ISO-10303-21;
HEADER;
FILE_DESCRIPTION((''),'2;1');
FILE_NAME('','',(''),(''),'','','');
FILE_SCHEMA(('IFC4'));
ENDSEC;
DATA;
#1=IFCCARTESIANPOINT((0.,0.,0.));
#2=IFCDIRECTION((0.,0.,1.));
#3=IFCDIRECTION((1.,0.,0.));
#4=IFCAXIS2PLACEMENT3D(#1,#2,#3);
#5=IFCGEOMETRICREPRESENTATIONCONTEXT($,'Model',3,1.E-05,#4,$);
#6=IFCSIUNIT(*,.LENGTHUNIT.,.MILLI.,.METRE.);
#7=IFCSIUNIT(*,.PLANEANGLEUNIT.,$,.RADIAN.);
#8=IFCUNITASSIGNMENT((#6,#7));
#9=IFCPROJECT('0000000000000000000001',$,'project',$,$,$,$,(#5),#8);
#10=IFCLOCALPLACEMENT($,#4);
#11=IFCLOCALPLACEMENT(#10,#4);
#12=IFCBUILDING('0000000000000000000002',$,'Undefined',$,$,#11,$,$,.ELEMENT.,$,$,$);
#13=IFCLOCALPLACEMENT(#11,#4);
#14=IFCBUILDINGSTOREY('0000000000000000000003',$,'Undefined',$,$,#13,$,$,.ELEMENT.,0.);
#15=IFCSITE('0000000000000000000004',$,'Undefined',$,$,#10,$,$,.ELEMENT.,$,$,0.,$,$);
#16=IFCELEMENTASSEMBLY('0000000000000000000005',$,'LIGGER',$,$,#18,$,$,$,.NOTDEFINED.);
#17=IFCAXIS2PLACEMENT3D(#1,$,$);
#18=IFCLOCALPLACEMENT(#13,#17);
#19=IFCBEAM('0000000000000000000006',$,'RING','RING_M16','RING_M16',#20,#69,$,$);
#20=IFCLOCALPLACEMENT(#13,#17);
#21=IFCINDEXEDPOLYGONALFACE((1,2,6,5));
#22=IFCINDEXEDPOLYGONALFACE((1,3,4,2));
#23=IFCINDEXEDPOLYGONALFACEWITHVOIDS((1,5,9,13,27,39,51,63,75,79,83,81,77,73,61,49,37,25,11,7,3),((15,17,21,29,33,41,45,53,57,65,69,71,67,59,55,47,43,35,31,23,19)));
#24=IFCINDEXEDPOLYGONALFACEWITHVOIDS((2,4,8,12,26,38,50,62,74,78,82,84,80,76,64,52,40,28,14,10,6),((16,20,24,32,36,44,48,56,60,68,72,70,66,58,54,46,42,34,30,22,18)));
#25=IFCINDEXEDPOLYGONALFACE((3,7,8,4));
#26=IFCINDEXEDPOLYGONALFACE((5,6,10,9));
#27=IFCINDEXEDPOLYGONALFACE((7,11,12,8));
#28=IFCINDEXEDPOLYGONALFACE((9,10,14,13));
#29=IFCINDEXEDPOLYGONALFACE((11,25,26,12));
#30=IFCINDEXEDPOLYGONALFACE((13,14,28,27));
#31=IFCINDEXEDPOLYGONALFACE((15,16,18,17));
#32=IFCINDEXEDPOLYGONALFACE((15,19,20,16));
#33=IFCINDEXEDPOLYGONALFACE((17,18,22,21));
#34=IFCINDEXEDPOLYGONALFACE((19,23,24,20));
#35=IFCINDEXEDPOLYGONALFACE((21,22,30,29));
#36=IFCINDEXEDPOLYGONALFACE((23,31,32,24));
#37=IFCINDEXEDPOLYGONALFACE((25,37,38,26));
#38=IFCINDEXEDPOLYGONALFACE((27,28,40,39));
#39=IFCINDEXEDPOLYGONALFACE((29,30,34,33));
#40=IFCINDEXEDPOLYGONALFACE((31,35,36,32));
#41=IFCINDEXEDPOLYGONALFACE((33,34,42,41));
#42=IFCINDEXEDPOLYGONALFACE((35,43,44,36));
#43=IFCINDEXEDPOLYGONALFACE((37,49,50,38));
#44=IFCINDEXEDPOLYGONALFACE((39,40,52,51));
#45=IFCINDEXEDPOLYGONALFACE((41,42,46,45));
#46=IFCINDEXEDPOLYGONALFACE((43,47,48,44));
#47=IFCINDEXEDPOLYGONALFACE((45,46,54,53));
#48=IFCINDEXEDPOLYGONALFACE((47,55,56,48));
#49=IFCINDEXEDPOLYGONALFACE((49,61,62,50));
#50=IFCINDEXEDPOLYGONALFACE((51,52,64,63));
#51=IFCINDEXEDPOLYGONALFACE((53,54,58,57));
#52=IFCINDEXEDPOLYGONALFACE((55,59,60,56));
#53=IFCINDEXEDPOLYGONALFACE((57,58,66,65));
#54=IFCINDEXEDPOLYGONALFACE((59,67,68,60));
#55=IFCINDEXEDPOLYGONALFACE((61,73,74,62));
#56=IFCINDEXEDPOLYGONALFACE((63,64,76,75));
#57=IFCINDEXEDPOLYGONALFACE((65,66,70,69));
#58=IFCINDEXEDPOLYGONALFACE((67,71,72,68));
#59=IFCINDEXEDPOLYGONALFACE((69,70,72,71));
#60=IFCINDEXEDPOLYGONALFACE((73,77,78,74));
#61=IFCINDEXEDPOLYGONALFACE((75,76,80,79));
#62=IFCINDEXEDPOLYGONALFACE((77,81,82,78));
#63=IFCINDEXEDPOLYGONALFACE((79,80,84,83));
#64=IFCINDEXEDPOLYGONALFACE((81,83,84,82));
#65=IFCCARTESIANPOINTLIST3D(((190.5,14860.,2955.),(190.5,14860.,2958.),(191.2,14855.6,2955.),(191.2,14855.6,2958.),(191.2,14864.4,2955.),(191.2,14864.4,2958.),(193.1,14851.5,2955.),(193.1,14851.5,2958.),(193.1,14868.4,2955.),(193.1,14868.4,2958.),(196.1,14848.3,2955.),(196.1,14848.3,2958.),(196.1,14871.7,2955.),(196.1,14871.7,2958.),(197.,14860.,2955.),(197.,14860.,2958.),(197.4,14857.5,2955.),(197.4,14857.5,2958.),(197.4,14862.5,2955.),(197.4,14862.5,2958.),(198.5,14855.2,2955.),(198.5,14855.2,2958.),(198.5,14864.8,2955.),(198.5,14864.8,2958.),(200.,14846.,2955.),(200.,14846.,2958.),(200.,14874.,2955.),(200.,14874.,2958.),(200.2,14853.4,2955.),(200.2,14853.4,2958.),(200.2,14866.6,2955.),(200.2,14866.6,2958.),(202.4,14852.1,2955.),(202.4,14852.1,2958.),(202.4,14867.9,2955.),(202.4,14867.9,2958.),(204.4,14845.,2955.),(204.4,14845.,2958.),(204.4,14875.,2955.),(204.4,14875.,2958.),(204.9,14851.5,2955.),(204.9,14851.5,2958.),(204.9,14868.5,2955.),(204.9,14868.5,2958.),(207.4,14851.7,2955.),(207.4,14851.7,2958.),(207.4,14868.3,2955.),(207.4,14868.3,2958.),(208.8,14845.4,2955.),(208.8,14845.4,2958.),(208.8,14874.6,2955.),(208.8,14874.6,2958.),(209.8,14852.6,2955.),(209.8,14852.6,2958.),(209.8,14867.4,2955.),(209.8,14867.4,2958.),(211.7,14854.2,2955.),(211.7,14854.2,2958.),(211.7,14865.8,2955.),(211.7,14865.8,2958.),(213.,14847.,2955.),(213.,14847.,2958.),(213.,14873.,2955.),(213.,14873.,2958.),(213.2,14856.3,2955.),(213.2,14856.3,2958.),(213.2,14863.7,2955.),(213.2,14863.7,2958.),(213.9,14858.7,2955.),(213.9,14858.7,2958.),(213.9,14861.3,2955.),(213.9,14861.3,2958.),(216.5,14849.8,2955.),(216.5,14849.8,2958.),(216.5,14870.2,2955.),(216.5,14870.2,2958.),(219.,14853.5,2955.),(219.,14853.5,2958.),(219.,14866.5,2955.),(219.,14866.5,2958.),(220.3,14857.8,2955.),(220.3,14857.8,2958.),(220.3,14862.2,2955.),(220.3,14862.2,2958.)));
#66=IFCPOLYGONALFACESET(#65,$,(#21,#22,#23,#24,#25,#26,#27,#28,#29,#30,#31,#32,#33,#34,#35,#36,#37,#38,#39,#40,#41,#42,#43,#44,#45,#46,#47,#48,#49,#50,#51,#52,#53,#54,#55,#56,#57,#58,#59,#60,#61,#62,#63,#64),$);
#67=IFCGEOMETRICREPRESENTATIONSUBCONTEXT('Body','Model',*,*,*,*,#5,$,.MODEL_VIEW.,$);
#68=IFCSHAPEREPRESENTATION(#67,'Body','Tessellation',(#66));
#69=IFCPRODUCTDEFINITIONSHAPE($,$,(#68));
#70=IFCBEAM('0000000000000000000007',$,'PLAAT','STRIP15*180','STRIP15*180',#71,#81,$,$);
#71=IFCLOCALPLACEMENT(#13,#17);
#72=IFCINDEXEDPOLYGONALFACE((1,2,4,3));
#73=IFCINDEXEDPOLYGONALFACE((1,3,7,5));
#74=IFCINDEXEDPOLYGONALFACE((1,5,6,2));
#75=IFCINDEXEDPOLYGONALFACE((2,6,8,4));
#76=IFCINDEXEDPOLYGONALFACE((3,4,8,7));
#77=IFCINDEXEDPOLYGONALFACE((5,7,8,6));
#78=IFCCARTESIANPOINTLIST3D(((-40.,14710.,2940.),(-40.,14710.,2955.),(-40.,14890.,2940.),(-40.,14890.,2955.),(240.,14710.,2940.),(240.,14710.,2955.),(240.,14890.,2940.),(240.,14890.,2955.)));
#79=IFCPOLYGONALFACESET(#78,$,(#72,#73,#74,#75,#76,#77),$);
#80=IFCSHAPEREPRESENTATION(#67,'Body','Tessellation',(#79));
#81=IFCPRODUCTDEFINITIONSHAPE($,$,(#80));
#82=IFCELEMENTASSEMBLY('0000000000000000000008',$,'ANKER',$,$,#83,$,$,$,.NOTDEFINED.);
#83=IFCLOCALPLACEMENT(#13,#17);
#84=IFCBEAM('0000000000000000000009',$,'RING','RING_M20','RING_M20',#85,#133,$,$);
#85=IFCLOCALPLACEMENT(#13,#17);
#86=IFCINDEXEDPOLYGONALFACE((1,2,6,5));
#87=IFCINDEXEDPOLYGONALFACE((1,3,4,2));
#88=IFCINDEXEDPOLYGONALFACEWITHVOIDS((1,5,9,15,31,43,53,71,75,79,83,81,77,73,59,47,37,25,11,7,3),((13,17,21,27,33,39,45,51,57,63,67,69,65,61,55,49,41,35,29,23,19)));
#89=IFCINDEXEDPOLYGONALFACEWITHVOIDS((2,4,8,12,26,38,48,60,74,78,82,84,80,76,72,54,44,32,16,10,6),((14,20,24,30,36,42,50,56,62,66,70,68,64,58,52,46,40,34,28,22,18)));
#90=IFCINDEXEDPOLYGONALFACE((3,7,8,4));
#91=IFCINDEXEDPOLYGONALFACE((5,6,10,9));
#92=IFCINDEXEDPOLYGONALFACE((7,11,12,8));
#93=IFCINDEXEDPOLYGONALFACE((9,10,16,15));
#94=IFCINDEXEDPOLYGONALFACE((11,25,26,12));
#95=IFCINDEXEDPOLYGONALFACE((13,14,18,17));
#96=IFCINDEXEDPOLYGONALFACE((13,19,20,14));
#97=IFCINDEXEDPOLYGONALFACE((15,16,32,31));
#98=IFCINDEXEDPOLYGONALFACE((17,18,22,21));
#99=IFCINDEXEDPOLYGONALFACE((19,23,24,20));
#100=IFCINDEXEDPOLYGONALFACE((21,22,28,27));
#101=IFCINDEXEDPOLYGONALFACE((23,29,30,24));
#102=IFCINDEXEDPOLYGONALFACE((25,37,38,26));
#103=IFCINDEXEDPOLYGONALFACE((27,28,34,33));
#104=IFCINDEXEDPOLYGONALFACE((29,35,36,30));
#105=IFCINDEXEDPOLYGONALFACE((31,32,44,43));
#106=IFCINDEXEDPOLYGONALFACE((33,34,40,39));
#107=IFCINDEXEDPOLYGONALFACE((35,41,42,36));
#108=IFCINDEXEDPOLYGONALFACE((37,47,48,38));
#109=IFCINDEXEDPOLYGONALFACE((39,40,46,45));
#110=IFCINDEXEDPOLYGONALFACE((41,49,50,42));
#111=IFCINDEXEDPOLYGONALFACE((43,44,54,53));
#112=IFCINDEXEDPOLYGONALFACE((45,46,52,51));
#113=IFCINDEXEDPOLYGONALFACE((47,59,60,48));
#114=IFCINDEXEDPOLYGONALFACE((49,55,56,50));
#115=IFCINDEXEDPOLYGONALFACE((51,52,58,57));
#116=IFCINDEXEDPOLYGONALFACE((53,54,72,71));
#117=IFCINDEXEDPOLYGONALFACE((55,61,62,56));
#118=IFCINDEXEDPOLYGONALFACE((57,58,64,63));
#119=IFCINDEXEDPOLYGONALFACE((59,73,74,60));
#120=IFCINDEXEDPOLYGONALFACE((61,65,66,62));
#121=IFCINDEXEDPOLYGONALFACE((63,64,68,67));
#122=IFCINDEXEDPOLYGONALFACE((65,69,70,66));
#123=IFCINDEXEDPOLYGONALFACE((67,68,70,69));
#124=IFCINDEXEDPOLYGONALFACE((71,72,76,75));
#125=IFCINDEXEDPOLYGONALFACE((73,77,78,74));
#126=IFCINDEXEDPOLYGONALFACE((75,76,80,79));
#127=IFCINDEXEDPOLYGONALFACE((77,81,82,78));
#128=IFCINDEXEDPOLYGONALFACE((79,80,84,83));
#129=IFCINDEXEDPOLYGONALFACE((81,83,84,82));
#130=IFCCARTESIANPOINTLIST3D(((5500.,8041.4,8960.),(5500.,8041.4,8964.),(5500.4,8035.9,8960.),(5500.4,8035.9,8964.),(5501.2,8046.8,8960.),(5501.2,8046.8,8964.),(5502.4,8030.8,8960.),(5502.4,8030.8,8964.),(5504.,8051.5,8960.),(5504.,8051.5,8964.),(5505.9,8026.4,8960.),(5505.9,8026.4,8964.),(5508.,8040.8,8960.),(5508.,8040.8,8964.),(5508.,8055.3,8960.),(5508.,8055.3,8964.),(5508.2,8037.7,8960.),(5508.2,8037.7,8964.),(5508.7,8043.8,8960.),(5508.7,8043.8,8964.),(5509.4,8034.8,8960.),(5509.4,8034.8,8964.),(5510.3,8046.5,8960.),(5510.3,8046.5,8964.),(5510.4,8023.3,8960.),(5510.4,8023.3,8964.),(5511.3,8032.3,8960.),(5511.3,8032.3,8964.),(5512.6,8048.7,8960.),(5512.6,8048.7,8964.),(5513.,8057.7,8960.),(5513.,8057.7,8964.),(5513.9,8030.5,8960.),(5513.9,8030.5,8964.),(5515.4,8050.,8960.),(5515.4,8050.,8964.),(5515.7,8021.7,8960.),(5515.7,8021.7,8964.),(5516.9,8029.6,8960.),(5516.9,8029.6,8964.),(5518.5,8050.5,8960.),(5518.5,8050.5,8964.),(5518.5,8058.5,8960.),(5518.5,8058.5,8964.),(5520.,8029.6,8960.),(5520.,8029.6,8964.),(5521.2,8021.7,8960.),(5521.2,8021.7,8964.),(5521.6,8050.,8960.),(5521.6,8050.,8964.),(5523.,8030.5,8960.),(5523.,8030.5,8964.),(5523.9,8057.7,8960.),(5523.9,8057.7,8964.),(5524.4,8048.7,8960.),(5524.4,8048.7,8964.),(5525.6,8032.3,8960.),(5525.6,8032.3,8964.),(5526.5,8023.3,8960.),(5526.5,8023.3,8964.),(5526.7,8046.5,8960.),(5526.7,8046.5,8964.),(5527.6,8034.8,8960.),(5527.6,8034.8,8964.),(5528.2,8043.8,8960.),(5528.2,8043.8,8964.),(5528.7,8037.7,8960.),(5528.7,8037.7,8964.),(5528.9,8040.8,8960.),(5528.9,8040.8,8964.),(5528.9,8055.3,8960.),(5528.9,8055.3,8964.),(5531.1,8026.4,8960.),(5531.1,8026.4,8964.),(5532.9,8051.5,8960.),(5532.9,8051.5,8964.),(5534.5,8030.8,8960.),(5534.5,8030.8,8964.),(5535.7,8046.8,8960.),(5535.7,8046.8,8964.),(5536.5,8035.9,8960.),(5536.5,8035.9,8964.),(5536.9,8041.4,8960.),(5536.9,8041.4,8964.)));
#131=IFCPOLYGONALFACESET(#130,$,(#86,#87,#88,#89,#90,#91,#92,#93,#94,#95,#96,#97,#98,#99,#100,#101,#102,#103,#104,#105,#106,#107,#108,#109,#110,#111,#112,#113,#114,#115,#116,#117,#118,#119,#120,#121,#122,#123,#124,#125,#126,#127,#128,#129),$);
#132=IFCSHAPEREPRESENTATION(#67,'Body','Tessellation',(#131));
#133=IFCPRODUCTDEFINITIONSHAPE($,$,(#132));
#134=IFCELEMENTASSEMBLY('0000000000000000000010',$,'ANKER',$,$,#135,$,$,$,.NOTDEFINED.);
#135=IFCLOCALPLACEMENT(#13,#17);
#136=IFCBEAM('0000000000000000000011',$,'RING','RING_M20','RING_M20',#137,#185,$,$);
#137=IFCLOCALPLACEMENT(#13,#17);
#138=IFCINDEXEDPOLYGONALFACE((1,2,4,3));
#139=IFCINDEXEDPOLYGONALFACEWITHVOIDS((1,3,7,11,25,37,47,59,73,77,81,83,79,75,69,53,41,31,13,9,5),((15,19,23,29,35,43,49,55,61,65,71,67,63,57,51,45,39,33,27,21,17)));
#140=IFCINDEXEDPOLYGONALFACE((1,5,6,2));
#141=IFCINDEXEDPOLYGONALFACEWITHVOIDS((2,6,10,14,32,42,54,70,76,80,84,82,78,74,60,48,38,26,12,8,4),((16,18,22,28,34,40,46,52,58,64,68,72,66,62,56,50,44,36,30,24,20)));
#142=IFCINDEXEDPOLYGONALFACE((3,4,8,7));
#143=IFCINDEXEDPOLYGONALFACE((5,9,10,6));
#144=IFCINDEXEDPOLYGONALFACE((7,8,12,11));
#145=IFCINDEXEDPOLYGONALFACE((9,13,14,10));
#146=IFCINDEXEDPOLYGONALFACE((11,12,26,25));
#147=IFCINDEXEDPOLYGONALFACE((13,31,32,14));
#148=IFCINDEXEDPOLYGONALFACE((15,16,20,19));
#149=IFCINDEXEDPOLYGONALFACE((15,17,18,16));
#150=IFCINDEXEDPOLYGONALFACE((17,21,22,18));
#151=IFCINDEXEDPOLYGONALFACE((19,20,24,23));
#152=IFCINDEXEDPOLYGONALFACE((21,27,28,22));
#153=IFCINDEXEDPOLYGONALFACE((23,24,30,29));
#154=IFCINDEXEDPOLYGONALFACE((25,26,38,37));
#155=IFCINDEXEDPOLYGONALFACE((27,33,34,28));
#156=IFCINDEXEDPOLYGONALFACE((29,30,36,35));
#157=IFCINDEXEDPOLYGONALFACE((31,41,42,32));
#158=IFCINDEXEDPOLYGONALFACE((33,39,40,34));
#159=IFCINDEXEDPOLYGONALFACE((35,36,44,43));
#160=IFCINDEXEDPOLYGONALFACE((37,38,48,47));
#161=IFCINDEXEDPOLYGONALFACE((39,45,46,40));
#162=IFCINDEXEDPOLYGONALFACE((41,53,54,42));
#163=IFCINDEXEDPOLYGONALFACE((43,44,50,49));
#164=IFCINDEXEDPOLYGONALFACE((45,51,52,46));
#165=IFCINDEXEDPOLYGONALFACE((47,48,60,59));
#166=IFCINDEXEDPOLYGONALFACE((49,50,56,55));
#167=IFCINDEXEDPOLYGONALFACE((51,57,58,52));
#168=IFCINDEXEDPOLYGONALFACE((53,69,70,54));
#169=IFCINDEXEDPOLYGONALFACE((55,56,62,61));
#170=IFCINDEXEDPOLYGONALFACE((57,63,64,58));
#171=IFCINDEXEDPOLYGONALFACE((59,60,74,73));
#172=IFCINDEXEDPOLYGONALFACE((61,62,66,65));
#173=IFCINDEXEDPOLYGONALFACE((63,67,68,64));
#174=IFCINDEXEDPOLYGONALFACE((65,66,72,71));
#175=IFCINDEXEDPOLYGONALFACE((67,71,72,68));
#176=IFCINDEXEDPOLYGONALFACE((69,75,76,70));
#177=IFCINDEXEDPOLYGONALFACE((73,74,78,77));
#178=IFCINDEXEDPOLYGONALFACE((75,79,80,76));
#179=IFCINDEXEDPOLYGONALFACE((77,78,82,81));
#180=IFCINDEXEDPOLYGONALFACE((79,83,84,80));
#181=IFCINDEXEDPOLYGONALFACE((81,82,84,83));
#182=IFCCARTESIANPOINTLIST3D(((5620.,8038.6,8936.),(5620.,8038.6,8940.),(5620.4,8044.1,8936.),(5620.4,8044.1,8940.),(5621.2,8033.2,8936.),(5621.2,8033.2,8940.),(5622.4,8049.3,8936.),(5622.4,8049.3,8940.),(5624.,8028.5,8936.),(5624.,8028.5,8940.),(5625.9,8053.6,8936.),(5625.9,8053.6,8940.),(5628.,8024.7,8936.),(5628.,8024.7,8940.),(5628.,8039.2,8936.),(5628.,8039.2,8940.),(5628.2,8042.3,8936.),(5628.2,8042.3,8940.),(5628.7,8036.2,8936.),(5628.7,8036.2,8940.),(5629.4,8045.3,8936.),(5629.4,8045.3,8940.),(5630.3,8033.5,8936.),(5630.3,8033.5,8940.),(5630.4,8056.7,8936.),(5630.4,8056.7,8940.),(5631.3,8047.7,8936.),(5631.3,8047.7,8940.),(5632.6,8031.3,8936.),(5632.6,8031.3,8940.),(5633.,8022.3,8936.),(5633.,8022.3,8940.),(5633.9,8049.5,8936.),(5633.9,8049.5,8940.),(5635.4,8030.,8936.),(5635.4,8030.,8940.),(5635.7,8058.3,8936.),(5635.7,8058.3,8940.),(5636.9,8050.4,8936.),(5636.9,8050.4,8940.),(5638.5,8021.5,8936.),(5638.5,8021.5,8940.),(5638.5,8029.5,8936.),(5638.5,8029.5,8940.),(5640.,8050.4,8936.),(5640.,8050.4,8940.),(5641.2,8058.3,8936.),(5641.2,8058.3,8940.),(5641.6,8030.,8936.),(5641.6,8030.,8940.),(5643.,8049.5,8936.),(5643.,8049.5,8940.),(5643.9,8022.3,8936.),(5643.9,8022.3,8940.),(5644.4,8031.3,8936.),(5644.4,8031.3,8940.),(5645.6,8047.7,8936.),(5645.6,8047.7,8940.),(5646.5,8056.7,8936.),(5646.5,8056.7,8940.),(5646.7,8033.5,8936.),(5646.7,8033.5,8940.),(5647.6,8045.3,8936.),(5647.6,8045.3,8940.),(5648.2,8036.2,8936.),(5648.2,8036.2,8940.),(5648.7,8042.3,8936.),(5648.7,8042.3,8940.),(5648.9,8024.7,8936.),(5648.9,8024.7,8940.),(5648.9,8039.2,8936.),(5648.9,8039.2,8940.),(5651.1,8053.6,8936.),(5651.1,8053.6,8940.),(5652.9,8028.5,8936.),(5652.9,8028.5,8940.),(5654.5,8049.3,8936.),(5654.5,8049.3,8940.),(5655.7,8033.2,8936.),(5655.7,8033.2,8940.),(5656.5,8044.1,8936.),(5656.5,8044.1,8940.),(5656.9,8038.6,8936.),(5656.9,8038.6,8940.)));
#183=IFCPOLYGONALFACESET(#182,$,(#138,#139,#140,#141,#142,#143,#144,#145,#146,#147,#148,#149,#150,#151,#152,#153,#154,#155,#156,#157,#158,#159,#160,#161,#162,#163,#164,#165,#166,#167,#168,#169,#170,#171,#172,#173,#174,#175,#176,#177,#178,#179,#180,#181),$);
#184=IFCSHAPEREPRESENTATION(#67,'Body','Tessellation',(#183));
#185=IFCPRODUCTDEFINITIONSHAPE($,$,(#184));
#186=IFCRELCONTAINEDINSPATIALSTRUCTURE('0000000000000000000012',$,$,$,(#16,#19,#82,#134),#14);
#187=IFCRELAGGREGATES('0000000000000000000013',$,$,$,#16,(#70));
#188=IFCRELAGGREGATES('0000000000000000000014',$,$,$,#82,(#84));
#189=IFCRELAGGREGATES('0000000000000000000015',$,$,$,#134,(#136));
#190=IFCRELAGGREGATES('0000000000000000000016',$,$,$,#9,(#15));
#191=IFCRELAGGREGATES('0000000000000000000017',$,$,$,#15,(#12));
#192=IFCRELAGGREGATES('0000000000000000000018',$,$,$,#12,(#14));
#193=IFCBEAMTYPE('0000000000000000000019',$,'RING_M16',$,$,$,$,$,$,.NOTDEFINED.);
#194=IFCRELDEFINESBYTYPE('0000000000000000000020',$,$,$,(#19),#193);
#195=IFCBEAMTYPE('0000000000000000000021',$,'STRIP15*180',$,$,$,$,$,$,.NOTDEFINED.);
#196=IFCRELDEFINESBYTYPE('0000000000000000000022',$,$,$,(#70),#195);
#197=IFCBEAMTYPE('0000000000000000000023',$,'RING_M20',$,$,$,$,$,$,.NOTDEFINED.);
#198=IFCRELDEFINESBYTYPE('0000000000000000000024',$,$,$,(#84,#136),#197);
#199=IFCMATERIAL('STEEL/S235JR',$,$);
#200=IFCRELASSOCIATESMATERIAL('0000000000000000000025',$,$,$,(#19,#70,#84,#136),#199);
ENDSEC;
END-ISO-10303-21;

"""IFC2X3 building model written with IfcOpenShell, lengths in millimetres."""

from ifc_helpers import new_model, si_unit, frame, origin_with_axes, origin_2d_with_axis, place, context, subcontext, project, spatial, rectangle, hollow_circle, extrude, material, type_object, element, aggregate, save


model = new_model("IFC2X3")

# Units and contexts
model_context = context("Model", 3, precision=1e-05, world=origin_with_axes())
body_context = subcontext(model_context, "Body", "Model", "MODEL_VIEW")
ifc_project = project(units=[si_unit("LENGTHUNIT", "METRE", prefix="MILLI"), si_unit("PLANEANGLEUNIT", "RADIAN")], contexts=[model_context])

# Site, building, storey
site_placement = place(None, origin_with_axes())
site = spatial("IfcSite", under=ifc_project, at=site_placement, Name="Undefined", CompositionType="ELEMENT", RefElevation=0.0)
building_placement = place(site_placement, origin_with_axes())
building = spatial("IfcBuilding", under=site, at=building_placement, Name="Undefined", CompositionType="ELEMENT")
storey_placement = place(building_placement, origin_with_axes())
storey = spatial("IfcBuildingStorey", under=building, at=storey_placement, Name="Undefined", CompositionType="ELEMENT", Elevation=0.0)

# Shared definitions
ifc_material = material(Name="STEEL/S235JR")

# Element assembly
assembly_1_placement = place(storey_placement, frame((810.1, 14800.0, 5743.0), z_axis=(0.0, 0.0, 1.0), x_axis=(1.0, 0.0, 0.0)))
assembly_1 = element("IfcElementAssembly", 1, at=assembly_1_placement, inside=storey, Name="LIGGER", PredefinedType="NOTDEFINED")

# Shared definitions
beam_type_1 = type_object("IfcBeamType", Name="RING_M16", PredefinedType="NOTDEFINED")

# Beams
beam_1_placement = place(storey_placement, frame((205.5, 14860.0, 2958.0), z_axis=(0.0, -1.0, 0.0), x_axis=(0.0, 0.0, -1.0)))
element("IfcBeam", 2, at=beam_1_placement, inside=storey, type_object=beam_type_1, material=ifc_material, Name="RING", Description="RING_M16", ObjectType="RING_M16", context=body_context, shape_type="SweptSolid", body=[
    extrude(hollow_circle(Radius=15.0, WallThickness=6.5, at=origin_2d_with_axis()), frame((3.0, 0.0, 0.0), z_axis=(-1.0, 0.0, 0.0), x_axis=(0.0, -1.0, 0.0)), (0.0, 0.0, 1.0), 3.0),
])
beam_type_2 = type_object("IfcBeamType", Name="STRIP15*180", PredefinedType="NOTDEFINED")
beam_2_placement = place(storey_placement, frame((100.0, 14710.0, 2947.5), z_axis=(-1.0, 0.0, 0.0), x_axis=(0.0, 1.0, 0.0)))
beam_2 = element("IfcBeam", 3, at=beam_2_placement, type_object=beam_type_2, material=ifc_material, Name="PLAAT", Description="STRIP15*180", ObjectType="STRIP15*180", context=body_context, shape_type="SweptSolid", body=[
    extrude(rectangle(XDim=15.0, YDim=280.0, at=origin_2d_with_axis()), frame((180.0, 0.0, 0.0), z_axis=(-1.0, 0.0, 0.0), x_axis=(0.0, -1.0, 0.0)), (0.0, 0.0, 1.0), 180.0),
])
aggregate(assembly_1, [beam_2])

# Element assembly, beam
assembly_2_placement = place(storey_placement, frame((5518.5, 8040.0, 9010.0), z_axis=(0.0, 1.0, 0.0), x_axis=(0.0, 0.0, -1.0)))
assembly_2 = element("IfcElementAssembly", 4, at=assembly_2_placement, inside=storey, Name="ANKER", PredefinedType="NOTDEFINED")
beam_type_3 = type_object("IfcBeamType", Name="RING_M20", PredefinedType="NOTDEFINED")
beam_3_placement = place(storey_placement, frame((5518.5, 8040.0, 8964.0), z_axis=(-1.0, 0.0, 0.0), x_axis=(0.0, 0.0, -1.0)))
beam_3 = element("IfcBeam", 5, at=beam_3_placement, type_object=beam_type_3, material=ifc_material, Name="RING", Description="RING_M20", ObjectType="RING_M20", context=body_context, shape_type="SweptSolid", body=[
    extrude(hollow_circle(Radius=18.5, WallThickness=8.0, at=origin_2d_with_axis()), frame((4.0, 0.0, 0.0), z_axis=(-1.0, 0.0, 0.0), x_axis=(0.0, -1.0, 0.0)), (0.0, 0.0, 1.0), 4.0),
])
aggregate(assembly_2, [beam_3])

# Element assembly, beam
assembly_3_placement = place(storey_placement, frame((5638.5, 8040.0, 9010.0), z_axis=(0.0, 1.0, 0.0), x_axis=(0.0, 0.0, -1.0)))
assembly_3 = element("IfcElementAssembly", 6, at=assembly_3_placement, inside=storey, Name="ANKER", PredefinedType="NOTDEFINED")
beam_4_placement = place(storey_placement, frame((5638.5, 8040.0, 8940.0), z_axis=(1.0, 0.0, 0.0), x_axis=(0.0, 0.0, -1.0)))
beam_4 = element("IfcBeam", 7, at=beam_4_placement, type_object=beam_type_3, material=ifc_material, Name="RING", Description="RING_M20", ObjectType="RING_M20", context=body_context, shape_type="SweptSolid", body=[
    extrude(hollow_circle(Radius=18.5, WallThickness=8.0, at=origin_2d_with_axis()), frame((4.0, 0.0, 0.0), z_axis=(-1.0, 0.0, 0.0), x_axis=(0.0, -1.0, 0.0)), (0.0, 0.0, 1.0), 4.0),
])
aggregate(assembly_3, [beam_4])

save(model, "model.ifc")
